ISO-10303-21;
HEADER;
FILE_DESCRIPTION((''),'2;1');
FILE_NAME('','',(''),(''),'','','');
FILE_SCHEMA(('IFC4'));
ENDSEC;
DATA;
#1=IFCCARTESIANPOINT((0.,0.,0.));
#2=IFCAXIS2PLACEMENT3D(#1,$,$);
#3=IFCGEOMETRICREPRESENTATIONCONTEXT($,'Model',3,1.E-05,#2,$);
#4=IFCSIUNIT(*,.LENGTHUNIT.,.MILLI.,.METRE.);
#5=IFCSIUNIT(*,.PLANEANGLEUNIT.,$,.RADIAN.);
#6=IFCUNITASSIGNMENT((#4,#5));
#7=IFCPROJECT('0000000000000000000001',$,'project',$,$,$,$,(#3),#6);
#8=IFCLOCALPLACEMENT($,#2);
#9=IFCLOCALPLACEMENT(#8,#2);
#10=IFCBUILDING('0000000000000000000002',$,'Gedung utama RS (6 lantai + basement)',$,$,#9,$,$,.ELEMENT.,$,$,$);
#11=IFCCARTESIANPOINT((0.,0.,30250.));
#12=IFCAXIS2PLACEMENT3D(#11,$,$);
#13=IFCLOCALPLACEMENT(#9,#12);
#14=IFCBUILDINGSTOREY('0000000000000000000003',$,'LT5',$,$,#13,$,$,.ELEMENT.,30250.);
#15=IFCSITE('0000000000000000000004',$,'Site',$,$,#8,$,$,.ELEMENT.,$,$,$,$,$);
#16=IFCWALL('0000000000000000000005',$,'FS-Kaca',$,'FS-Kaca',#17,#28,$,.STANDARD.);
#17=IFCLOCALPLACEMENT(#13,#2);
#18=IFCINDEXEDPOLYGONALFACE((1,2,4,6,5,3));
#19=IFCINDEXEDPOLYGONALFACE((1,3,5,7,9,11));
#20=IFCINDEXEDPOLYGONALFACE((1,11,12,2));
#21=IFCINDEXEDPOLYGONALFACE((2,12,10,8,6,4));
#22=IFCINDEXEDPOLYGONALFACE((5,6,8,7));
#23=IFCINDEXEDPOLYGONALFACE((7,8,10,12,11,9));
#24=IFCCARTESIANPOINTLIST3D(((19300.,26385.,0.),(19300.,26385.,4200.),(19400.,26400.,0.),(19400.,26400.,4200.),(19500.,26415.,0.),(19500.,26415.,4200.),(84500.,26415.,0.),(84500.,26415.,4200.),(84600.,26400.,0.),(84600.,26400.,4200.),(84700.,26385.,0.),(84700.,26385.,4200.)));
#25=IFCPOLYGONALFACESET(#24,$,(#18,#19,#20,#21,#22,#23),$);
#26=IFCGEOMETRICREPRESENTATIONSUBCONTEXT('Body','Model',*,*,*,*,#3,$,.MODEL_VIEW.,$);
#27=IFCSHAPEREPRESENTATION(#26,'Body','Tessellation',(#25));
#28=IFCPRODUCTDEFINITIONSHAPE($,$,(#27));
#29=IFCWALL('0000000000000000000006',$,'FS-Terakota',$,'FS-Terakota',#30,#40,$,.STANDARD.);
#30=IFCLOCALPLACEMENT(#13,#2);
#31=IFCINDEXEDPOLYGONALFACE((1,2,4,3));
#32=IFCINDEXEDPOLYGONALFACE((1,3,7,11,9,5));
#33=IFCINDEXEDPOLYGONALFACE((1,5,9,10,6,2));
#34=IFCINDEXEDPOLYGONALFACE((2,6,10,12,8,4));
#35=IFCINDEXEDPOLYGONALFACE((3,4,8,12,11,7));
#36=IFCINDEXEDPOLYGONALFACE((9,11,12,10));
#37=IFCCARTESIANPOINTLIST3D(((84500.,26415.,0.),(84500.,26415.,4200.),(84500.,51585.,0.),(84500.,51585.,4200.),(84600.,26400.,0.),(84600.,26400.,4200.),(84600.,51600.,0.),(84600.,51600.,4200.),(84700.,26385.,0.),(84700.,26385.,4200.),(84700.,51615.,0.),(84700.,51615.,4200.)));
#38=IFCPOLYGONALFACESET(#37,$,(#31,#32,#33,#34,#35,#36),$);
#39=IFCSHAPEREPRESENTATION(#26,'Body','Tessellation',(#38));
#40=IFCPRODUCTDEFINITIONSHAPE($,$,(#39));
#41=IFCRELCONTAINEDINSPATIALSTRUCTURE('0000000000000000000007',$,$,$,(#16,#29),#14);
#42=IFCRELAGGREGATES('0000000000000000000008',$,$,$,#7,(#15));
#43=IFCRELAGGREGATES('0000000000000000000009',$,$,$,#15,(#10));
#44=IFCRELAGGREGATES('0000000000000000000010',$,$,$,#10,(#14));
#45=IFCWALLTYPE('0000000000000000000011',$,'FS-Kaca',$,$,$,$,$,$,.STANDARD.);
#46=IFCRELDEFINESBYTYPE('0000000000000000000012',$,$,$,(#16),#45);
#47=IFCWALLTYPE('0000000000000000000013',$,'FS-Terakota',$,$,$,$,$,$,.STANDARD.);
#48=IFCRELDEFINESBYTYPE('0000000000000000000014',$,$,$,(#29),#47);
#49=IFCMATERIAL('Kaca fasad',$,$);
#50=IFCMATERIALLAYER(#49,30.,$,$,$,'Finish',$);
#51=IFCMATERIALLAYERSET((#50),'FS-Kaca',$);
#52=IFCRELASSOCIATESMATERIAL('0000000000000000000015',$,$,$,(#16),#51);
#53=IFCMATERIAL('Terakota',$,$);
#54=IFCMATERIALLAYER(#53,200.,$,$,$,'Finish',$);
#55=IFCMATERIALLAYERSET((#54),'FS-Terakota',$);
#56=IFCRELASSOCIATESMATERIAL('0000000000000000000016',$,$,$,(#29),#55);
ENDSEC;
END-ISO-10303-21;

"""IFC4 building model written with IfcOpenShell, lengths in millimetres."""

from ifc_helpers import new_model, si_unit, frame, origin, place, context, subcontext, project, spatial, polyline, outline, extrude, material, layer, layer_set, layer_usage, type_object, element, save


model = new_model("IFC4")

# Units and contexts
model_context = context("Model", 3, precision=1e-05, world=origin())
body_context = subcontext(model_context, "Body", "Model", "MODEL_VIEW")
ifc_project = project(units=[si_unit("LENGTHUNIT", "METRE", prefix="MILLI"), si_unit("PLANEANGLEUNIT", "RADIAN")], contexts=[model_context])

# Site, building, storey
site_placement = place(None, origin())
site = spatial("IfcSite", under=ifc_project, at=site_placement, Name="Site", CompositionType="ELEMENT")
building_placement = place(site_placement, origin())
building = spatial("IfcBuilding", under=site, at=building_placement, Name="Gedung utama RS (6 lantai + basement)", CompositionType="ELEMENT")
storey_placement = place(building_placement, frame((0.0, 0.0, 30250.0)))
storey = spatial("IfcBuildingStorey", under=building, at=storey_placement, Name="LT5", CompositionType="ELEMENT", Elevation=30250.0)

# Walls
ifc_material_1 = material(Name="Kaca fasad")
ifc_layer_1 = layer(ifc_material_1, 30.0, Category="Finish")
ifc_layer_set_1 = layer_set([ifc_layer_1], Name="FS-Kaca")
ifc_layer_usage_1 = layer_usage(ifc_layer_set_1, "AXIS2", "NEGATIVE", 15.0)
wall_type_1 = type_object("IfcWallType", Name="FS-Kaca", PredefinedType="STANDARD")
wall_1_placement = place(storey_placement, frame((84600.0, 26400.0, 0.0), z_axis=(0.0, 0.0, 1.0), x_axis=(-1.0, 0.0, 0.0)))
element("IfcWall", 1, at=wall_1_placement, inside=storey, type_object=wall_type_1, material=ifc_layer_usage_1, Name="FS-Kaca", ObjectType="FS-Kaca", PredefinedType="STANDARD", context=body_context, shape_type="SweptSolid", body=[
    extrude(outline(polyline([(100.0, -15.0), (0.0, 0.0), (-100.0, 15.0), (65300.0, 15.0), (65200.0, 0.0), (65100.0, -15.0), (100.0, -15.0)])), origin(), (0.0, 0.0, 1.0), 4200.0),
])
ifc_material_2 = material(Name="Terakota")
ifc_layer_2 = layer(ifc_material_2, 200.0, Category="Finish")
ifc_layer_set_2 = layer_set([ifc_layer_2], Name="FS-Terakota")
ifc_layer_usage_2 = layer_usage(ifc_layer_set_2, "AXIS2", "NEGATIVE", 100.0)
wall_type_2 = type_object("IfcWallType", Name="FS-Terakota", PredefinedType="STANDARD")
wall_2_placement = place(storey_placement, frame((84600.0, 51600.0, 0.0), z_axis=(0.0, 0.0, 1.0), x_axis=(0.0, -1.0, 0.0)))
element("IfcWall", 2, at=wall_2_placement, inside=storey, type_object=wall_type_2, material=ifc_layer_usage_2, Name="FS-Terakota", ObjectType="FS-Terakota", PredefinedType="STANDARD", context=body_context, shape_type="SweptSolid", body=[
    extrude(outline(polyline([(15.0, -100.0), (0.0, 0.0), (-15.0, 100.0), (25215.0, 100.0), (25200.0, 0.0), (25185.0, -100.0), (15.0, -100.0)])), origin(), (0.0, 0.0, 1.0), 4200.0),
])

save(model, "model.ifc")
